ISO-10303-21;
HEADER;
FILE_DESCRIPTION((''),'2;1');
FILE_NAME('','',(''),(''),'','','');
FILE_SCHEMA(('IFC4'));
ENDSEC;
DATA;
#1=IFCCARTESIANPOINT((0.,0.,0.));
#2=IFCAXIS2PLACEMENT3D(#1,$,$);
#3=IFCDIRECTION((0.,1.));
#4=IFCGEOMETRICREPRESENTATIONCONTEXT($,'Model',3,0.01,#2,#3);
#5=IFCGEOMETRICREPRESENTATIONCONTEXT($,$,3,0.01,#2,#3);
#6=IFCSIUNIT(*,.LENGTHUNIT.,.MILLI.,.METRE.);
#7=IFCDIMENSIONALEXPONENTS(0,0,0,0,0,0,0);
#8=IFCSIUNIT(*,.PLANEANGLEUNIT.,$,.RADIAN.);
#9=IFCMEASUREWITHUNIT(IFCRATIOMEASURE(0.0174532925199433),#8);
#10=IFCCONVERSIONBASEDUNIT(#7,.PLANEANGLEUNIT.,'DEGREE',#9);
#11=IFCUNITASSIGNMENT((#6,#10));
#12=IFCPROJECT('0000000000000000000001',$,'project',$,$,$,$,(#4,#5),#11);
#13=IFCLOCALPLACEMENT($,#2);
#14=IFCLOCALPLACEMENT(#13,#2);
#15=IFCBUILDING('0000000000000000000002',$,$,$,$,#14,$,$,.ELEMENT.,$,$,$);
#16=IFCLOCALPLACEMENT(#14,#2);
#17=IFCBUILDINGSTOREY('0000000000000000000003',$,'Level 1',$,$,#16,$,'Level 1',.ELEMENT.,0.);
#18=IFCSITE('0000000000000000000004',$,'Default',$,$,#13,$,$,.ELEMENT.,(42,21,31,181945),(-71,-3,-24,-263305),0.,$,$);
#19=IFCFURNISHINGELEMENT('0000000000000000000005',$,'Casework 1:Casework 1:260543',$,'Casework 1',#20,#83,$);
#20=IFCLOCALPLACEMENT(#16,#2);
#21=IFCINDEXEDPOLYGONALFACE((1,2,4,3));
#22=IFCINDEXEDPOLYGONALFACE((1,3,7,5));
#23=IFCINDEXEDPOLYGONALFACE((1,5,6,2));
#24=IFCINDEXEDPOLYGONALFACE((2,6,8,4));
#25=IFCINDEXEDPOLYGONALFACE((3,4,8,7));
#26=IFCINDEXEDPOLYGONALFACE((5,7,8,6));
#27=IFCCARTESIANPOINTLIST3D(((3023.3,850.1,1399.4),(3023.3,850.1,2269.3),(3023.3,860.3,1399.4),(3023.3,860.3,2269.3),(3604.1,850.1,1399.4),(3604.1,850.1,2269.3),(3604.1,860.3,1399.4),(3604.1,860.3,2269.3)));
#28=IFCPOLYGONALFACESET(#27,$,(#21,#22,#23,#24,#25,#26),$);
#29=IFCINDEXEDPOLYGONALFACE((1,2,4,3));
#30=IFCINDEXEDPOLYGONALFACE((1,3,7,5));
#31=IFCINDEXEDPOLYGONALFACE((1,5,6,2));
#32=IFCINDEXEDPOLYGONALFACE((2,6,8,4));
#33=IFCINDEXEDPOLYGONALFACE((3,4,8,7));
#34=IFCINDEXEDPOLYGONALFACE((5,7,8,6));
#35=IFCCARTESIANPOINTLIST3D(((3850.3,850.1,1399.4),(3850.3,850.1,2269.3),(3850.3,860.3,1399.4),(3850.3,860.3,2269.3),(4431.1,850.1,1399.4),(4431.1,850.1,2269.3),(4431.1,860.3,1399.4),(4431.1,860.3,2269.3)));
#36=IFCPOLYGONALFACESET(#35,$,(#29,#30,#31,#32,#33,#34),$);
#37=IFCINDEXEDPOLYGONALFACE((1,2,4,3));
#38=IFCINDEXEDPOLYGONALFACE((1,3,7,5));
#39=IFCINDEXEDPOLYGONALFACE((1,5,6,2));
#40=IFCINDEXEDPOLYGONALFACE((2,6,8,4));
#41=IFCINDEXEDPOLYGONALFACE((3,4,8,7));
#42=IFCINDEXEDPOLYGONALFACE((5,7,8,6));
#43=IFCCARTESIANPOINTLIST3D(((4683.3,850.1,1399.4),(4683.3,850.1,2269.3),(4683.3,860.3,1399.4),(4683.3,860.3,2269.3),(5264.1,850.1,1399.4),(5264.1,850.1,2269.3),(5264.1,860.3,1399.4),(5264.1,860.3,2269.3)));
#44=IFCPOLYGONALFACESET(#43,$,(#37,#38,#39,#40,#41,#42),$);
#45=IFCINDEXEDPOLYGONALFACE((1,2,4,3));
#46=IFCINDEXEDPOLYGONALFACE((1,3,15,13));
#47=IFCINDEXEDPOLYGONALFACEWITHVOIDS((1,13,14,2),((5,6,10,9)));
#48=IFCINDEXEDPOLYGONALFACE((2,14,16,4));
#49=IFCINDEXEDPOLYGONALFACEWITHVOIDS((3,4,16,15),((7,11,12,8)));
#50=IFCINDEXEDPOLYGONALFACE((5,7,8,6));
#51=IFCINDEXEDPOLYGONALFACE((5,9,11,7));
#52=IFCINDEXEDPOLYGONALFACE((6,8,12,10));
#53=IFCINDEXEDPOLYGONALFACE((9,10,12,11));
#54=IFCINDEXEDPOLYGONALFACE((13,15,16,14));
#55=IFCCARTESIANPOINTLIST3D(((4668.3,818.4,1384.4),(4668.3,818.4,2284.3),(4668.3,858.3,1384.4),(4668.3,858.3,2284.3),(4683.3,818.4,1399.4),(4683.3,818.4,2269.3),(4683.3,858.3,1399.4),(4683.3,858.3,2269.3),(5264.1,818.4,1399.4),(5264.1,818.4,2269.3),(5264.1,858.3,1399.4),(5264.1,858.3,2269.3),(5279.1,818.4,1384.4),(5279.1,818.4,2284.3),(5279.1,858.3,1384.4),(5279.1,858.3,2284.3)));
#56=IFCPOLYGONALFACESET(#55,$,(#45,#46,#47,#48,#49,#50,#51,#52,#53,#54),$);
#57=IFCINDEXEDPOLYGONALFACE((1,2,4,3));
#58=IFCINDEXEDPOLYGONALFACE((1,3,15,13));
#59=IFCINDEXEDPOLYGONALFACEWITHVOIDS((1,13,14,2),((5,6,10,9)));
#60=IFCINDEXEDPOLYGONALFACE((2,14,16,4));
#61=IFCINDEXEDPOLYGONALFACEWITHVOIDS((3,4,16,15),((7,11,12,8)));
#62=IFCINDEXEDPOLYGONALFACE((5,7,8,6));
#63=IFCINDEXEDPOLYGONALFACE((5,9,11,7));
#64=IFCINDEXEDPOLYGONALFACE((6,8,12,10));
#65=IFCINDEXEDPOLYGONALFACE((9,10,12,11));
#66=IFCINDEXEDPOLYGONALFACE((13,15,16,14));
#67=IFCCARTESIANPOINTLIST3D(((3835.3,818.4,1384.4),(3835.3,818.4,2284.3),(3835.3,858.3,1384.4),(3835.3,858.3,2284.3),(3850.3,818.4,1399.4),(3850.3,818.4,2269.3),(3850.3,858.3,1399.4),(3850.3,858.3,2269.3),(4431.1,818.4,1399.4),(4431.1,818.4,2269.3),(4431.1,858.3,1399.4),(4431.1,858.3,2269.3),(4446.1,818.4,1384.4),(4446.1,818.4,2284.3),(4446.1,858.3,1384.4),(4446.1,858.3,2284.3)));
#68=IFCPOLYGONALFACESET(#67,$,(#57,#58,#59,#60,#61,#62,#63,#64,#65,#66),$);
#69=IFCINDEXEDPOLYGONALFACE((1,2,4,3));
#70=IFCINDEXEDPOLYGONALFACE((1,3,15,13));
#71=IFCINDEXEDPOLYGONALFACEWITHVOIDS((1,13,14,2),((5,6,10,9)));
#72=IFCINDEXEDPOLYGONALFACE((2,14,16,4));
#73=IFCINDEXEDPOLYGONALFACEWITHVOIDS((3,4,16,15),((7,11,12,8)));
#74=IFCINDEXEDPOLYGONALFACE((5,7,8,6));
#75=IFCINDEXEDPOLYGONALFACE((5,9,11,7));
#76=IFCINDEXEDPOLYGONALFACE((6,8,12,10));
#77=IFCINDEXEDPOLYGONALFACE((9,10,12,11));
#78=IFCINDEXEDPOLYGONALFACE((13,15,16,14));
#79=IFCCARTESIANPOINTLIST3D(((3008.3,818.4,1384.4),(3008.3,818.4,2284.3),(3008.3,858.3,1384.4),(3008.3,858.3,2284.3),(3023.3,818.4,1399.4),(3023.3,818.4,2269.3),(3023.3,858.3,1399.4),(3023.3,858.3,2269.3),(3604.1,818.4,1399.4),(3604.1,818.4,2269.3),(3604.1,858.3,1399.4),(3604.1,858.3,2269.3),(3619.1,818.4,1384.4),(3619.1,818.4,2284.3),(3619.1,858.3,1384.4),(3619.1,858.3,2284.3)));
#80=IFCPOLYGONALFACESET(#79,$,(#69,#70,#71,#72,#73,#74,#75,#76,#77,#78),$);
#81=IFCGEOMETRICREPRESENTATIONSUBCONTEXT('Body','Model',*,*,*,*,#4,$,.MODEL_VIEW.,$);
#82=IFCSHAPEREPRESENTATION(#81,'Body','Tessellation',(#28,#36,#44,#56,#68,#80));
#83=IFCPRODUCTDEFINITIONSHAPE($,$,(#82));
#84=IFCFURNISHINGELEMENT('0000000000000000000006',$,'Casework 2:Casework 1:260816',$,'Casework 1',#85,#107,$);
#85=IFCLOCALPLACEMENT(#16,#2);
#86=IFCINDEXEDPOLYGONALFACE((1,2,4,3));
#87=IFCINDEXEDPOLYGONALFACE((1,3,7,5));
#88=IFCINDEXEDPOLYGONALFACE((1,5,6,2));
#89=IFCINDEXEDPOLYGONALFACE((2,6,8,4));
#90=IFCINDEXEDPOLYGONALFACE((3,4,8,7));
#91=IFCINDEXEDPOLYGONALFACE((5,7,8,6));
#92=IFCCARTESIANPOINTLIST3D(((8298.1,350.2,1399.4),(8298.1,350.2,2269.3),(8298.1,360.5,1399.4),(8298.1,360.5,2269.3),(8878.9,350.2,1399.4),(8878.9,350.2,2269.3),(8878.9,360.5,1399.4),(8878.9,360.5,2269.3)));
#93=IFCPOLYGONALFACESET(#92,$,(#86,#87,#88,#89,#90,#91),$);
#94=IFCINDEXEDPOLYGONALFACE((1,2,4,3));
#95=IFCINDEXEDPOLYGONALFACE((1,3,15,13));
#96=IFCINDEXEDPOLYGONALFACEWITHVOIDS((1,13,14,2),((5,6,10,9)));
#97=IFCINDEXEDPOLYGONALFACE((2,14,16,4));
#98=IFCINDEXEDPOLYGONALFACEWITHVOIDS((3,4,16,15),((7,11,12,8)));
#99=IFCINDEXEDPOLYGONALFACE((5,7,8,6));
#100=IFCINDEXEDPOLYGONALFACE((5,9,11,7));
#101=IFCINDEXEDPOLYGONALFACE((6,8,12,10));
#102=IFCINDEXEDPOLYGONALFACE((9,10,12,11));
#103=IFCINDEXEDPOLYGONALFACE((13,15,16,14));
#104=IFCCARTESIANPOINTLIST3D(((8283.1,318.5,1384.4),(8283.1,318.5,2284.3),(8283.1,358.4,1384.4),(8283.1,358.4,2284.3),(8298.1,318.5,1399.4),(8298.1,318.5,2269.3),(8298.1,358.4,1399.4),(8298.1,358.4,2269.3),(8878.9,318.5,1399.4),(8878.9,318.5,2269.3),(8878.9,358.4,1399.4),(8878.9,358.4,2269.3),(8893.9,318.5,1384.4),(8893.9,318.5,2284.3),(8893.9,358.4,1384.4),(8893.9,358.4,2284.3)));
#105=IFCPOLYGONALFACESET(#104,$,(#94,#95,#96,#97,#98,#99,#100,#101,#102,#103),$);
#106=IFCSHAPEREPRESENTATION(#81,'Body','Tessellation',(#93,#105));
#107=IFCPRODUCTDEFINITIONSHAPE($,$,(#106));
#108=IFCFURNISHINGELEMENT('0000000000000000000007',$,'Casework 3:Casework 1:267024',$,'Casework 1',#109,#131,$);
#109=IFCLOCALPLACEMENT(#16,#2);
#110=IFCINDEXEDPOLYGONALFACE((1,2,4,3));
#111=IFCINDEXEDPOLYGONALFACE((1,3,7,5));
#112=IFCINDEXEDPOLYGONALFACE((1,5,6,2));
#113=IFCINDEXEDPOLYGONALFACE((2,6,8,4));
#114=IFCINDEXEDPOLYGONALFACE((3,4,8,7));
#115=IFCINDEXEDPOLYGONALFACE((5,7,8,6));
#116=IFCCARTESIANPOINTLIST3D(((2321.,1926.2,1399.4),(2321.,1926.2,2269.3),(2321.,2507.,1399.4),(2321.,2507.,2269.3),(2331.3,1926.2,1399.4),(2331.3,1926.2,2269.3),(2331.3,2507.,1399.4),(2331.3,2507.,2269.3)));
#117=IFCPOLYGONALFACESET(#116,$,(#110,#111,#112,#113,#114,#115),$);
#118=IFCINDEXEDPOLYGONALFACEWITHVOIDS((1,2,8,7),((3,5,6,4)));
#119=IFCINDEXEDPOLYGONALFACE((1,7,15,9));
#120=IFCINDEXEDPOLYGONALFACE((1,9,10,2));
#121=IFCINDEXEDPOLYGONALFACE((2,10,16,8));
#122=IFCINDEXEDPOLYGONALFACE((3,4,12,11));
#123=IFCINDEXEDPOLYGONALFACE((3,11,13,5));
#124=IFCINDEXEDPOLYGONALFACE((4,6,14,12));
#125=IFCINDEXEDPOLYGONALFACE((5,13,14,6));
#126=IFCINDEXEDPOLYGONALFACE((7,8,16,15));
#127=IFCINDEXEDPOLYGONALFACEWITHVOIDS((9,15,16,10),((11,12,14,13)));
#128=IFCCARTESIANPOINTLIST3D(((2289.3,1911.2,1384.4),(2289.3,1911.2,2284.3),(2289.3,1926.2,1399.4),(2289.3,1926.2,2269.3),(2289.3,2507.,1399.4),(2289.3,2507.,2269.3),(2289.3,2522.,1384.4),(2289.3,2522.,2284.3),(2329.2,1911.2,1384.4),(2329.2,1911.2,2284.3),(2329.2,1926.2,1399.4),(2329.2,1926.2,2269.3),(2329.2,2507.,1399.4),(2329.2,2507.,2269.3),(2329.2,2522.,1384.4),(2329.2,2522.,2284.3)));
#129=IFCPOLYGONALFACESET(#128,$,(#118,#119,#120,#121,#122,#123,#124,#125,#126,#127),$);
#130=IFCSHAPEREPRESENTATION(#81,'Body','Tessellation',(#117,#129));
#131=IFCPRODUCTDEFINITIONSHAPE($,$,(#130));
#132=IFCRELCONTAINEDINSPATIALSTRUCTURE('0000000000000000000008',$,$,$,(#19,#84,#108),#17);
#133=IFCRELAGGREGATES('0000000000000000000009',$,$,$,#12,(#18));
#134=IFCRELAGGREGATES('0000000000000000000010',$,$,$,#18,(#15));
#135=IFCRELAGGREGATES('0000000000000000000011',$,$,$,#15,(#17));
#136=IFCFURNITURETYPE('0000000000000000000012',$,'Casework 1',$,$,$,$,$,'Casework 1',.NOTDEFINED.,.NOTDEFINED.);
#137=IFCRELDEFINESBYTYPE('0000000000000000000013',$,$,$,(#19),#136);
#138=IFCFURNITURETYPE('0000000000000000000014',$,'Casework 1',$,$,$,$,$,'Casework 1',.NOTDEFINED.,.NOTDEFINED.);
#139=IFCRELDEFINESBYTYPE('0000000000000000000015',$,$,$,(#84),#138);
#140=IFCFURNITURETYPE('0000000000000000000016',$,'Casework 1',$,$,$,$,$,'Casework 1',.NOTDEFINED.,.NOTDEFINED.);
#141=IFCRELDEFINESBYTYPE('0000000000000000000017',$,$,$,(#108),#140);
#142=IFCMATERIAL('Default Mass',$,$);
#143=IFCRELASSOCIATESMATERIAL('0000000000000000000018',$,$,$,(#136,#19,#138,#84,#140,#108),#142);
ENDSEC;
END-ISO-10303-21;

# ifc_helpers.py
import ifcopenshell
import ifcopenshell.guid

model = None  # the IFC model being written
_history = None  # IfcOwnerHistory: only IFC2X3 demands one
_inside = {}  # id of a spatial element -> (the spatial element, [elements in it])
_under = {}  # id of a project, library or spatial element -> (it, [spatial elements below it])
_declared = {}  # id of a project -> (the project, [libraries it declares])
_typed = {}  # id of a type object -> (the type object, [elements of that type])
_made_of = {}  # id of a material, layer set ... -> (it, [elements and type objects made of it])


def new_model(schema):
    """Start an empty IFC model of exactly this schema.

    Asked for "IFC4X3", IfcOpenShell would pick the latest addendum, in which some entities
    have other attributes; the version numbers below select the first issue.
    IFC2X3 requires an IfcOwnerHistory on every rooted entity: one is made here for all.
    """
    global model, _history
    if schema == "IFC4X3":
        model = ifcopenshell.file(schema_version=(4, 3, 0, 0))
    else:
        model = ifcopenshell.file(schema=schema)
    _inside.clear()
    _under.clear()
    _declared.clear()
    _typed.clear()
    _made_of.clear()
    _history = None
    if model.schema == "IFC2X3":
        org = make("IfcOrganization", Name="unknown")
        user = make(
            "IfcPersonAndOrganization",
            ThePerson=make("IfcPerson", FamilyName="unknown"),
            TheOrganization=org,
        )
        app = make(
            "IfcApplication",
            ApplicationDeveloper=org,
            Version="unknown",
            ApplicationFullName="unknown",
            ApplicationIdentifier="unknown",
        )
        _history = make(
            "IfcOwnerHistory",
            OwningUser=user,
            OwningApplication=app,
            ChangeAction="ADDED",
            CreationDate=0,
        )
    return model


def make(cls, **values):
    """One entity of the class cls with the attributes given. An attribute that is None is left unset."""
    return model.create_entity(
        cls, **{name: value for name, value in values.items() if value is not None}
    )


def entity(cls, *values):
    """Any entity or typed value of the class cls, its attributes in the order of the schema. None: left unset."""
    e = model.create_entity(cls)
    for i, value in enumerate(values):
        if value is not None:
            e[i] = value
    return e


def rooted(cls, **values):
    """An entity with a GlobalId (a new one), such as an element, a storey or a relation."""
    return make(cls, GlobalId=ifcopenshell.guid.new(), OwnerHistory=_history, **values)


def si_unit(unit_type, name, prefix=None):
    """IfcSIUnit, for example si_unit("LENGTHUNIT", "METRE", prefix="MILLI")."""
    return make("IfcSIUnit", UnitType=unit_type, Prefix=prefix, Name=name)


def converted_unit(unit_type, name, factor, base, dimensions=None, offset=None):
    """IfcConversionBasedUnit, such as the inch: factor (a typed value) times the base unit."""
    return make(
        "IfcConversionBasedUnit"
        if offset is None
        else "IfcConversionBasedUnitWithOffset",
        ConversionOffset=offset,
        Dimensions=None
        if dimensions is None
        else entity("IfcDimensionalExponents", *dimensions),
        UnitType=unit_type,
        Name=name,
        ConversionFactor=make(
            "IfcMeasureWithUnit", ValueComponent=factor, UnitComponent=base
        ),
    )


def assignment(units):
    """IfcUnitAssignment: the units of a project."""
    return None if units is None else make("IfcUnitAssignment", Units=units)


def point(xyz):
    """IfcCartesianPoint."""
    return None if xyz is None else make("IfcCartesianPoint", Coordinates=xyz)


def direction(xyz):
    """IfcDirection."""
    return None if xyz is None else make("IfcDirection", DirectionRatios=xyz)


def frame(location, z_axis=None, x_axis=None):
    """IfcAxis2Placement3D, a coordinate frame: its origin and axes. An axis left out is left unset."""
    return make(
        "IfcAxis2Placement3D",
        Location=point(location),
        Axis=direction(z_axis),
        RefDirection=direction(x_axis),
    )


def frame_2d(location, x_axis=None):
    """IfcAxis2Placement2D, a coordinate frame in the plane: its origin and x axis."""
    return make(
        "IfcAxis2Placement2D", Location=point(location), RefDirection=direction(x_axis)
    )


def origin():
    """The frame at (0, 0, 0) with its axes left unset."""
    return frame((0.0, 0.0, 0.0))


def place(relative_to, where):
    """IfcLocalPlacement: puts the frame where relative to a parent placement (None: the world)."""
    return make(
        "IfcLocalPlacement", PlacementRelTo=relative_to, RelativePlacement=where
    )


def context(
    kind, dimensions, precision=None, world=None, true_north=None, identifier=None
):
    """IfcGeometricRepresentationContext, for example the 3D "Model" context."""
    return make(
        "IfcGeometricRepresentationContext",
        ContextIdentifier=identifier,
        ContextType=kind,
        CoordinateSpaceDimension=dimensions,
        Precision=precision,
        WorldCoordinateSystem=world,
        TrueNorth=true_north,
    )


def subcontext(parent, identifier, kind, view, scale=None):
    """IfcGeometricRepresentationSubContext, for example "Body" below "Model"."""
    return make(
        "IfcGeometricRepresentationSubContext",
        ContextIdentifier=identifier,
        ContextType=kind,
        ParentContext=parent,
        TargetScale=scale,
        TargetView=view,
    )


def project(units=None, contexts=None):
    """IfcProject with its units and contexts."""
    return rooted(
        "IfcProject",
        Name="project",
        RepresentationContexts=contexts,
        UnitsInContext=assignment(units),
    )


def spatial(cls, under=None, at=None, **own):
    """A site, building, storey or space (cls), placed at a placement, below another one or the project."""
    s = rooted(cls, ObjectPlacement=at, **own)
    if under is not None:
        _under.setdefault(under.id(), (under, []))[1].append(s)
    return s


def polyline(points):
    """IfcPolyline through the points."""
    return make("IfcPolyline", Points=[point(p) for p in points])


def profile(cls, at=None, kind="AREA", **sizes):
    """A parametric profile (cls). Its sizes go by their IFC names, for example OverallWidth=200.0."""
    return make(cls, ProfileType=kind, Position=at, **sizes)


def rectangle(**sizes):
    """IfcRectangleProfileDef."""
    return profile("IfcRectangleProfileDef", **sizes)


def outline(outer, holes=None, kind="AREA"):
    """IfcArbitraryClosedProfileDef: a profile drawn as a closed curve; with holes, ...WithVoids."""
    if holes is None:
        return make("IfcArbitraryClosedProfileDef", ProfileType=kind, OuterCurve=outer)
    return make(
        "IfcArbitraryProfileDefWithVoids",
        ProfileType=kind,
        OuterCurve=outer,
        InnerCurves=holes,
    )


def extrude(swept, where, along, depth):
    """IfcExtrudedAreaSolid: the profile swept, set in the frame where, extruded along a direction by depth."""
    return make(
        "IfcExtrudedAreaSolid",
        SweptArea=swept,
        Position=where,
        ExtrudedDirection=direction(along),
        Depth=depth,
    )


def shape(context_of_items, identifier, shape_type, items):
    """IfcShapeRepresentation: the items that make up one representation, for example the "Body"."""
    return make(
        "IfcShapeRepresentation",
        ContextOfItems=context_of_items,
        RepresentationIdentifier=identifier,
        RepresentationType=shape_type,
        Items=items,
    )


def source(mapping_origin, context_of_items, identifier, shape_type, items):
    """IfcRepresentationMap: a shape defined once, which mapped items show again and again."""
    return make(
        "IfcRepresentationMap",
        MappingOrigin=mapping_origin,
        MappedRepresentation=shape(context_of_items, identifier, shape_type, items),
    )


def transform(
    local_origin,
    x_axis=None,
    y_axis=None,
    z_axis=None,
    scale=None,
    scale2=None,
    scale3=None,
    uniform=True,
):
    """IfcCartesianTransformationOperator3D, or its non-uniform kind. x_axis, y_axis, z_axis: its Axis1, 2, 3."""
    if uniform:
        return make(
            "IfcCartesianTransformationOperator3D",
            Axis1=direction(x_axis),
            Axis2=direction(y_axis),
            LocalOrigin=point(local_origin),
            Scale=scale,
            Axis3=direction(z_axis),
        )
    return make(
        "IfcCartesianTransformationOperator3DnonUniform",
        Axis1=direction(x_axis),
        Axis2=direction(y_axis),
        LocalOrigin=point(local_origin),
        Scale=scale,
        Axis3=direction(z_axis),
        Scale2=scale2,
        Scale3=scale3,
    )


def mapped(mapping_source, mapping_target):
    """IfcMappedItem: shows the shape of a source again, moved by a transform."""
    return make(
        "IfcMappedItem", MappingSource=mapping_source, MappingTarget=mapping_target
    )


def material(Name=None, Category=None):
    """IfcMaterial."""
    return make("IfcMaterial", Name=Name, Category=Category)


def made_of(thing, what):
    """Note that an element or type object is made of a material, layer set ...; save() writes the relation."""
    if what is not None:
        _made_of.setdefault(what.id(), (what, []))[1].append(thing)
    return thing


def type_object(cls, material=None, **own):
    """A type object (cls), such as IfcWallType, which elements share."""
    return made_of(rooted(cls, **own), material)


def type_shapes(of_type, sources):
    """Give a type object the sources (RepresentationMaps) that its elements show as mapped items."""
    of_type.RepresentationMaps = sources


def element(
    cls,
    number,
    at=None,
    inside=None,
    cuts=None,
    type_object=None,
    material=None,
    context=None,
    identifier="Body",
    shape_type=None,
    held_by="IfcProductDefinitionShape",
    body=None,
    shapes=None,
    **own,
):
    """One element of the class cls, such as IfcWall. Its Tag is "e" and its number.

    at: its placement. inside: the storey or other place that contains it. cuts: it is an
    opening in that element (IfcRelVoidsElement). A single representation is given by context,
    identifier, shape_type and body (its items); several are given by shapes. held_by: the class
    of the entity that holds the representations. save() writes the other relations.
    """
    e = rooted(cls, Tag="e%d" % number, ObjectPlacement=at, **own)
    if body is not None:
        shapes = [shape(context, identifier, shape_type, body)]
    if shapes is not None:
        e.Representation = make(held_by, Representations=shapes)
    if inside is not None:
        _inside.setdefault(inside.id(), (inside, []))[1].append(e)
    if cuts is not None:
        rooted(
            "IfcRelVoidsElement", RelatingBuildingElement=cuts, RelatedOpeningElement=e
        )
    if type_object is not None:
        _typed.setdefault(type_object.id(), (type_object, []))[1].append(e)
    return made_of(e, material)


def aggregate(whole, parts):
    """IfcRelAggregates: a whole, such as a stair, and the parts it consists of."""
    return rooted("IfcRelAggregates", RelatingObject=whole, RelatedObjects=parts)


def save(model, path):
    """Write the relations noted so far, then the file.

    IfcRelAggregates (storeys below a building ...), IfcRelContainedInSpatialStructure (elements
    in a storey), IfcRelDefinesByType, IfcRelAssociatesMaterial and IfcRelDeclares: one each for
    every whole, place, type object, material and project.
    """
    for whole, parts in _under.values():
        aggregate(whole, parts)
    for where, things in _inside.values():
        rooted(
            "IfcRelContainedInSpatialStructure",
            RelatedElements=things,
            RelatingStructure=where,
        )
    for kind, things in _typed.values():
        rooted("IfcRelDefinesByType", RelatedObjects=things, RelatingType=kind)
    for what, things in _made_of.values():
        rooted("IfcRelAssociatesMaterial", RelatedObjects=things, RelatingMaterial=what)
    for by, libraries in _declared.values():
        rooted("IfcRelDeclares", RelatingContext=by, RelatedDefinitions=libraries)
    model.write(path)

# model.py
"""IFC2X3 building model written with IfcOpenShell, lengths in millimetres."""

from ifc_helpers import new_model, entity, si_unit, converted_unit, direction, frame, frame_2d, origin, place, context, subcontext, project, spatial, polyline, rectangle, outline, extrude, source, transform, mapped, material, type_object, type_shapes, element, save


model = new_model("IFC2X3")

# Units and contexts
model_context = context("Model", 3, precision=0.01, world=origin(), true_north=direction((0.0, 1.0)))
context_of_model = context(None, 3, precision=0.01, world=origin(), true_north=direction((0.0, 1.0)))
body_context = subcontext(model_context, "Body", "Model", "MODEL_VIEW")
ifc_project = project(units=[si_unit("LENGTHUNIT", "METRE", prefix="MILLI"), converted_unit("PLANEANGLEUNIT", "DEGREE", entity("IfcRatioMeasure", 0.0174532925199433), si_unit("PLANEANGLEUNIT", "RADIAN"), dimensions=[0, 0, 0, 0, 0, 0, 0])], contexts=[model_context, context_of_model])

# Site, building, storey
site_placement = place(None, origin())
site = spatial("IfcSite", under=ifc_project, at=site_placement, Name="Default", CompositionType="ELEMENT", RefLatitude=(42, 21, 31, 181945), RefLongitude=(-71, -3, -24, -263305), RefElevation=0.0)
building_placement = place(site_placement, origin())
building = spatial("IfcBuilding", under=site, at=building_placement, CompositionType="ELEMENT")
storey_placement = place(building_placement, origin())
storey = spatial("IfcBuildingStorey", under=building, at=storey_placement, Name="Level 1", LongName="Level 1", CompositionType="ELEMENT", Elevation=0.0)

# Furnishing elements
ifc_material_1 = material(Name="Default Mass")
furniture_type_1 = type_object("IfcFurnitureType", Name="Casework 1", ElementType="Casework 1", AssemblyPlace="NOTDEFINED", material=ifc_material_1)
shared_shape_1 = source(origin(), body_context, "Body", "SweptSolid", [
    extrude(rectangle(XDim=10.3, YDim=580.8, at=frame_2d((0.0, 0.0), x_axis=(1.0, 0.0))), frame((3313.7, 855.2, 1399.4), z_axis=(0.0, 0.0, 1.0), x_axis=(0.0, -1.0, 0.0)), (0.0, 0.0, 1.0), 869.9),
    extrude(rectangle(XDim=10.3, YDim=580.8, at=frame_2d((0.0, 0.0), x_axis=(1.0, 0.0))), frame((4140.7, 855.2, 1399.4), z_axis=(0.0, 0.0, 1.0), x_axis=(0.0, -1.0, 0.0)), (0.0, 0.0, 1.0), 869.9),
    extrude(rectangle(XDim=10.3, YDim=580.8, at=frame_2d((0.0, 0.0), x_axis=(1.0, 0.0))), frame((4973.7, 855.2, 1399.4), z_axis=(0.0, 0.0, 1.0), x_axis=(0.0, -1.0, 0.0)), (0.0, 0.0, 1.0), 869.9),
    extrude(outline(polyline([(-305.4, -450.0), (305.4, -450.0), (305.4, 450.0), (-305.4, 450.0), (-305.4, -450.0)]), holes=[polyline([(-290.4, -435.0), (-290.4, 435.0), (290.4, 435.0), (290.4, -435.0), (-290.4, -435.0)])]), frame((4973.7, 818.4, 1834.4), z_axis=(0.0, 1.0, 0.0), x_axis=(1.0, 0.0, 0.0)), (0.0, 0.0, 1.0), 39.9),
    extrude(outline(polyline([(-305.4, -450.0), (305.4, -450.0), (305.4, 450.0), (-305.4, 450.0), (-305.4, -450.0)]), holes=[polyline([(-290.4, -435.0), (-290.4, 435.0), (290.4, 435.0), (290.4, -435.0), (-290.4, -435.0)])]), frame((4140.7, 818.4, 1834.4), z_axis=(0.0, 1.0, 0.0), x_axis=(1.0, 0.0, 0.0)), (0.0, 0.0, 1.0), 39.9),
    extrude(outline(polyline([(-305.4, -450.0), (305.4, -450.0), (305.4, 450.0), (-305.4, 450.0), (-305.4, -450.0)]), holes=[polyline([(-290.4, -435.0), (-290.4, 435.0), (290.4, 435.0), (290.4, -435.0), (-290.4, -435.0)])]), frame((3313.7, 818.4, 1834.4), z_axis=(0.0, 1.0, 0.0), x_axis=(1.0, 0.0, 0.0)), (0.0, 0.0, 1.0), 39.9),
])
type_shapes(furniture_type_1, [shared_shape_1])
furnishing_1_placement = place(storey_placement, origin())
element("IfcFurnishingElement", 1, at=furnishing_1_placement, inside=storey, type_object=furniture_type_1, material=ifc_material_1, Name="Casework 1:Casework 1:260543", ObjectType="Casework 1", context=body_context, shape_type="MappedRepresentation", body=[
    mapped(shared_shape_1, transform((0.0, 0.0, 0.0), scale=1.0)),
])
furniture_type_2 = type_object("IfcFurnitureType", Name="Casework 1", ElementType="Casework 1", AssemblyPlace="NOTDEFINED", material=ifc_material_1)
shared_shape_2 = source(origin(), body_context, "Body", "SweptSolid", [
    extrude(rectangle(XDim=10.3, YDim=580.8, at=frame_2d((0.0, 0.0), x_axis=(1.0, 0.0))), frame((8471.6, 1035.3, 1399.4), z_axis=(0.0, 0.0, 1.0), x_axis=(0.0, -1.0, 0.0)), (0.0, 0.0, 1.0), 869.9),
    extrude(outline(polyline([(-305.4, -450.0), (305.4, -450.0), (305.4, 450.0), (-305.4, 450.0), (-305.4, -450.0)]), holes=[polyline([(-290.4, -435.0), (-290.4, 435.0), (290.4, 435.0), (290.4, -435.0), (-290.4, -435.0)])]), frame((8471.6, 998.5, 1834.4), z_axis=(0.0, 1.0, 0.0), x_axis=(1.0, 0.0, 0.0)), (0.0, 0.0, 1.0), 39.9),
])
type_shapes(furniture_type_2, [shared_shape_2])
furnishing_2_placement = place(storey_placement, frame((116.9, -680.0, 0.0)))
element("IfcFurnishingElement", 2, at=furnishing_2_placement, inside=storey, type_object=furniture_type_2, material=ifc_material_1, Name="Casework 2:Casework 1:260816", ObjectType="Casework 1", context=body_context, shape_type="MappedRepresentation", body=[
    mapped(shared_shape_2, transform((0.0, 0.0, 0.0), scale=1.0)),
])
furniture_type_3 = type_object("IfcFurnitureType", Name="Casework 1", ElementType="Casework 1", AssemblyPlace="NOTDEFINED", material=ifc_material_1)
shared_shape_3 = source(origin(), body_context, "Body", "SweptSolid", [
    extrude(rectangle(XDim=10.3, YDim=580.8, at=frame_2d((0.0, 0.0), x_axis=(1.0, 0.0))), frame((2326.2, 2216.6, 1399.4), z_axis=(0.0, 0.0, 1.0), x_axis=(-1.0, 0.0, 0.0)), (0.0, 0.0, 1.0), 869.9),
    extrude(outline(polyline([(-305.4, -450.0), (305.4, -450.0), (305.4, 450.0), (-305.4, 450.0), (-305.4, -450.0)]), holes=[polyline([(-290.4, -435.0), (-290.4, 435.0), (290.4, 435.0), (290.4, -435.0), (-290.4, -435.0)])]), frame((2289.3, 2216.6, 1834.4), z_axis=(1.0, 0.0, 0.0), x_axis=(0.0, -1.0, 0.0)), (0.0, 0.0, 1.0), 39.9),
])
type_shapes(furniture_type_3, [shared_shape_3])
furnishing_3_placement = place(storey_placement, origin())
element("IfcFurnishingElement", 3, at=furnishing_3_placement, inside=storey, type_object=furniture_type_3, material=ifc_material_1, Name="Casework 3:Casework 1:267024", ObjectType="Casework 1", context=body_context, shape_type="MappedRepresentation", body=[
    mapped(shared_shape_3, transform((0.0, 0.0, 0.0), scale=1.0)),
])

save(model, "model.ifc")
